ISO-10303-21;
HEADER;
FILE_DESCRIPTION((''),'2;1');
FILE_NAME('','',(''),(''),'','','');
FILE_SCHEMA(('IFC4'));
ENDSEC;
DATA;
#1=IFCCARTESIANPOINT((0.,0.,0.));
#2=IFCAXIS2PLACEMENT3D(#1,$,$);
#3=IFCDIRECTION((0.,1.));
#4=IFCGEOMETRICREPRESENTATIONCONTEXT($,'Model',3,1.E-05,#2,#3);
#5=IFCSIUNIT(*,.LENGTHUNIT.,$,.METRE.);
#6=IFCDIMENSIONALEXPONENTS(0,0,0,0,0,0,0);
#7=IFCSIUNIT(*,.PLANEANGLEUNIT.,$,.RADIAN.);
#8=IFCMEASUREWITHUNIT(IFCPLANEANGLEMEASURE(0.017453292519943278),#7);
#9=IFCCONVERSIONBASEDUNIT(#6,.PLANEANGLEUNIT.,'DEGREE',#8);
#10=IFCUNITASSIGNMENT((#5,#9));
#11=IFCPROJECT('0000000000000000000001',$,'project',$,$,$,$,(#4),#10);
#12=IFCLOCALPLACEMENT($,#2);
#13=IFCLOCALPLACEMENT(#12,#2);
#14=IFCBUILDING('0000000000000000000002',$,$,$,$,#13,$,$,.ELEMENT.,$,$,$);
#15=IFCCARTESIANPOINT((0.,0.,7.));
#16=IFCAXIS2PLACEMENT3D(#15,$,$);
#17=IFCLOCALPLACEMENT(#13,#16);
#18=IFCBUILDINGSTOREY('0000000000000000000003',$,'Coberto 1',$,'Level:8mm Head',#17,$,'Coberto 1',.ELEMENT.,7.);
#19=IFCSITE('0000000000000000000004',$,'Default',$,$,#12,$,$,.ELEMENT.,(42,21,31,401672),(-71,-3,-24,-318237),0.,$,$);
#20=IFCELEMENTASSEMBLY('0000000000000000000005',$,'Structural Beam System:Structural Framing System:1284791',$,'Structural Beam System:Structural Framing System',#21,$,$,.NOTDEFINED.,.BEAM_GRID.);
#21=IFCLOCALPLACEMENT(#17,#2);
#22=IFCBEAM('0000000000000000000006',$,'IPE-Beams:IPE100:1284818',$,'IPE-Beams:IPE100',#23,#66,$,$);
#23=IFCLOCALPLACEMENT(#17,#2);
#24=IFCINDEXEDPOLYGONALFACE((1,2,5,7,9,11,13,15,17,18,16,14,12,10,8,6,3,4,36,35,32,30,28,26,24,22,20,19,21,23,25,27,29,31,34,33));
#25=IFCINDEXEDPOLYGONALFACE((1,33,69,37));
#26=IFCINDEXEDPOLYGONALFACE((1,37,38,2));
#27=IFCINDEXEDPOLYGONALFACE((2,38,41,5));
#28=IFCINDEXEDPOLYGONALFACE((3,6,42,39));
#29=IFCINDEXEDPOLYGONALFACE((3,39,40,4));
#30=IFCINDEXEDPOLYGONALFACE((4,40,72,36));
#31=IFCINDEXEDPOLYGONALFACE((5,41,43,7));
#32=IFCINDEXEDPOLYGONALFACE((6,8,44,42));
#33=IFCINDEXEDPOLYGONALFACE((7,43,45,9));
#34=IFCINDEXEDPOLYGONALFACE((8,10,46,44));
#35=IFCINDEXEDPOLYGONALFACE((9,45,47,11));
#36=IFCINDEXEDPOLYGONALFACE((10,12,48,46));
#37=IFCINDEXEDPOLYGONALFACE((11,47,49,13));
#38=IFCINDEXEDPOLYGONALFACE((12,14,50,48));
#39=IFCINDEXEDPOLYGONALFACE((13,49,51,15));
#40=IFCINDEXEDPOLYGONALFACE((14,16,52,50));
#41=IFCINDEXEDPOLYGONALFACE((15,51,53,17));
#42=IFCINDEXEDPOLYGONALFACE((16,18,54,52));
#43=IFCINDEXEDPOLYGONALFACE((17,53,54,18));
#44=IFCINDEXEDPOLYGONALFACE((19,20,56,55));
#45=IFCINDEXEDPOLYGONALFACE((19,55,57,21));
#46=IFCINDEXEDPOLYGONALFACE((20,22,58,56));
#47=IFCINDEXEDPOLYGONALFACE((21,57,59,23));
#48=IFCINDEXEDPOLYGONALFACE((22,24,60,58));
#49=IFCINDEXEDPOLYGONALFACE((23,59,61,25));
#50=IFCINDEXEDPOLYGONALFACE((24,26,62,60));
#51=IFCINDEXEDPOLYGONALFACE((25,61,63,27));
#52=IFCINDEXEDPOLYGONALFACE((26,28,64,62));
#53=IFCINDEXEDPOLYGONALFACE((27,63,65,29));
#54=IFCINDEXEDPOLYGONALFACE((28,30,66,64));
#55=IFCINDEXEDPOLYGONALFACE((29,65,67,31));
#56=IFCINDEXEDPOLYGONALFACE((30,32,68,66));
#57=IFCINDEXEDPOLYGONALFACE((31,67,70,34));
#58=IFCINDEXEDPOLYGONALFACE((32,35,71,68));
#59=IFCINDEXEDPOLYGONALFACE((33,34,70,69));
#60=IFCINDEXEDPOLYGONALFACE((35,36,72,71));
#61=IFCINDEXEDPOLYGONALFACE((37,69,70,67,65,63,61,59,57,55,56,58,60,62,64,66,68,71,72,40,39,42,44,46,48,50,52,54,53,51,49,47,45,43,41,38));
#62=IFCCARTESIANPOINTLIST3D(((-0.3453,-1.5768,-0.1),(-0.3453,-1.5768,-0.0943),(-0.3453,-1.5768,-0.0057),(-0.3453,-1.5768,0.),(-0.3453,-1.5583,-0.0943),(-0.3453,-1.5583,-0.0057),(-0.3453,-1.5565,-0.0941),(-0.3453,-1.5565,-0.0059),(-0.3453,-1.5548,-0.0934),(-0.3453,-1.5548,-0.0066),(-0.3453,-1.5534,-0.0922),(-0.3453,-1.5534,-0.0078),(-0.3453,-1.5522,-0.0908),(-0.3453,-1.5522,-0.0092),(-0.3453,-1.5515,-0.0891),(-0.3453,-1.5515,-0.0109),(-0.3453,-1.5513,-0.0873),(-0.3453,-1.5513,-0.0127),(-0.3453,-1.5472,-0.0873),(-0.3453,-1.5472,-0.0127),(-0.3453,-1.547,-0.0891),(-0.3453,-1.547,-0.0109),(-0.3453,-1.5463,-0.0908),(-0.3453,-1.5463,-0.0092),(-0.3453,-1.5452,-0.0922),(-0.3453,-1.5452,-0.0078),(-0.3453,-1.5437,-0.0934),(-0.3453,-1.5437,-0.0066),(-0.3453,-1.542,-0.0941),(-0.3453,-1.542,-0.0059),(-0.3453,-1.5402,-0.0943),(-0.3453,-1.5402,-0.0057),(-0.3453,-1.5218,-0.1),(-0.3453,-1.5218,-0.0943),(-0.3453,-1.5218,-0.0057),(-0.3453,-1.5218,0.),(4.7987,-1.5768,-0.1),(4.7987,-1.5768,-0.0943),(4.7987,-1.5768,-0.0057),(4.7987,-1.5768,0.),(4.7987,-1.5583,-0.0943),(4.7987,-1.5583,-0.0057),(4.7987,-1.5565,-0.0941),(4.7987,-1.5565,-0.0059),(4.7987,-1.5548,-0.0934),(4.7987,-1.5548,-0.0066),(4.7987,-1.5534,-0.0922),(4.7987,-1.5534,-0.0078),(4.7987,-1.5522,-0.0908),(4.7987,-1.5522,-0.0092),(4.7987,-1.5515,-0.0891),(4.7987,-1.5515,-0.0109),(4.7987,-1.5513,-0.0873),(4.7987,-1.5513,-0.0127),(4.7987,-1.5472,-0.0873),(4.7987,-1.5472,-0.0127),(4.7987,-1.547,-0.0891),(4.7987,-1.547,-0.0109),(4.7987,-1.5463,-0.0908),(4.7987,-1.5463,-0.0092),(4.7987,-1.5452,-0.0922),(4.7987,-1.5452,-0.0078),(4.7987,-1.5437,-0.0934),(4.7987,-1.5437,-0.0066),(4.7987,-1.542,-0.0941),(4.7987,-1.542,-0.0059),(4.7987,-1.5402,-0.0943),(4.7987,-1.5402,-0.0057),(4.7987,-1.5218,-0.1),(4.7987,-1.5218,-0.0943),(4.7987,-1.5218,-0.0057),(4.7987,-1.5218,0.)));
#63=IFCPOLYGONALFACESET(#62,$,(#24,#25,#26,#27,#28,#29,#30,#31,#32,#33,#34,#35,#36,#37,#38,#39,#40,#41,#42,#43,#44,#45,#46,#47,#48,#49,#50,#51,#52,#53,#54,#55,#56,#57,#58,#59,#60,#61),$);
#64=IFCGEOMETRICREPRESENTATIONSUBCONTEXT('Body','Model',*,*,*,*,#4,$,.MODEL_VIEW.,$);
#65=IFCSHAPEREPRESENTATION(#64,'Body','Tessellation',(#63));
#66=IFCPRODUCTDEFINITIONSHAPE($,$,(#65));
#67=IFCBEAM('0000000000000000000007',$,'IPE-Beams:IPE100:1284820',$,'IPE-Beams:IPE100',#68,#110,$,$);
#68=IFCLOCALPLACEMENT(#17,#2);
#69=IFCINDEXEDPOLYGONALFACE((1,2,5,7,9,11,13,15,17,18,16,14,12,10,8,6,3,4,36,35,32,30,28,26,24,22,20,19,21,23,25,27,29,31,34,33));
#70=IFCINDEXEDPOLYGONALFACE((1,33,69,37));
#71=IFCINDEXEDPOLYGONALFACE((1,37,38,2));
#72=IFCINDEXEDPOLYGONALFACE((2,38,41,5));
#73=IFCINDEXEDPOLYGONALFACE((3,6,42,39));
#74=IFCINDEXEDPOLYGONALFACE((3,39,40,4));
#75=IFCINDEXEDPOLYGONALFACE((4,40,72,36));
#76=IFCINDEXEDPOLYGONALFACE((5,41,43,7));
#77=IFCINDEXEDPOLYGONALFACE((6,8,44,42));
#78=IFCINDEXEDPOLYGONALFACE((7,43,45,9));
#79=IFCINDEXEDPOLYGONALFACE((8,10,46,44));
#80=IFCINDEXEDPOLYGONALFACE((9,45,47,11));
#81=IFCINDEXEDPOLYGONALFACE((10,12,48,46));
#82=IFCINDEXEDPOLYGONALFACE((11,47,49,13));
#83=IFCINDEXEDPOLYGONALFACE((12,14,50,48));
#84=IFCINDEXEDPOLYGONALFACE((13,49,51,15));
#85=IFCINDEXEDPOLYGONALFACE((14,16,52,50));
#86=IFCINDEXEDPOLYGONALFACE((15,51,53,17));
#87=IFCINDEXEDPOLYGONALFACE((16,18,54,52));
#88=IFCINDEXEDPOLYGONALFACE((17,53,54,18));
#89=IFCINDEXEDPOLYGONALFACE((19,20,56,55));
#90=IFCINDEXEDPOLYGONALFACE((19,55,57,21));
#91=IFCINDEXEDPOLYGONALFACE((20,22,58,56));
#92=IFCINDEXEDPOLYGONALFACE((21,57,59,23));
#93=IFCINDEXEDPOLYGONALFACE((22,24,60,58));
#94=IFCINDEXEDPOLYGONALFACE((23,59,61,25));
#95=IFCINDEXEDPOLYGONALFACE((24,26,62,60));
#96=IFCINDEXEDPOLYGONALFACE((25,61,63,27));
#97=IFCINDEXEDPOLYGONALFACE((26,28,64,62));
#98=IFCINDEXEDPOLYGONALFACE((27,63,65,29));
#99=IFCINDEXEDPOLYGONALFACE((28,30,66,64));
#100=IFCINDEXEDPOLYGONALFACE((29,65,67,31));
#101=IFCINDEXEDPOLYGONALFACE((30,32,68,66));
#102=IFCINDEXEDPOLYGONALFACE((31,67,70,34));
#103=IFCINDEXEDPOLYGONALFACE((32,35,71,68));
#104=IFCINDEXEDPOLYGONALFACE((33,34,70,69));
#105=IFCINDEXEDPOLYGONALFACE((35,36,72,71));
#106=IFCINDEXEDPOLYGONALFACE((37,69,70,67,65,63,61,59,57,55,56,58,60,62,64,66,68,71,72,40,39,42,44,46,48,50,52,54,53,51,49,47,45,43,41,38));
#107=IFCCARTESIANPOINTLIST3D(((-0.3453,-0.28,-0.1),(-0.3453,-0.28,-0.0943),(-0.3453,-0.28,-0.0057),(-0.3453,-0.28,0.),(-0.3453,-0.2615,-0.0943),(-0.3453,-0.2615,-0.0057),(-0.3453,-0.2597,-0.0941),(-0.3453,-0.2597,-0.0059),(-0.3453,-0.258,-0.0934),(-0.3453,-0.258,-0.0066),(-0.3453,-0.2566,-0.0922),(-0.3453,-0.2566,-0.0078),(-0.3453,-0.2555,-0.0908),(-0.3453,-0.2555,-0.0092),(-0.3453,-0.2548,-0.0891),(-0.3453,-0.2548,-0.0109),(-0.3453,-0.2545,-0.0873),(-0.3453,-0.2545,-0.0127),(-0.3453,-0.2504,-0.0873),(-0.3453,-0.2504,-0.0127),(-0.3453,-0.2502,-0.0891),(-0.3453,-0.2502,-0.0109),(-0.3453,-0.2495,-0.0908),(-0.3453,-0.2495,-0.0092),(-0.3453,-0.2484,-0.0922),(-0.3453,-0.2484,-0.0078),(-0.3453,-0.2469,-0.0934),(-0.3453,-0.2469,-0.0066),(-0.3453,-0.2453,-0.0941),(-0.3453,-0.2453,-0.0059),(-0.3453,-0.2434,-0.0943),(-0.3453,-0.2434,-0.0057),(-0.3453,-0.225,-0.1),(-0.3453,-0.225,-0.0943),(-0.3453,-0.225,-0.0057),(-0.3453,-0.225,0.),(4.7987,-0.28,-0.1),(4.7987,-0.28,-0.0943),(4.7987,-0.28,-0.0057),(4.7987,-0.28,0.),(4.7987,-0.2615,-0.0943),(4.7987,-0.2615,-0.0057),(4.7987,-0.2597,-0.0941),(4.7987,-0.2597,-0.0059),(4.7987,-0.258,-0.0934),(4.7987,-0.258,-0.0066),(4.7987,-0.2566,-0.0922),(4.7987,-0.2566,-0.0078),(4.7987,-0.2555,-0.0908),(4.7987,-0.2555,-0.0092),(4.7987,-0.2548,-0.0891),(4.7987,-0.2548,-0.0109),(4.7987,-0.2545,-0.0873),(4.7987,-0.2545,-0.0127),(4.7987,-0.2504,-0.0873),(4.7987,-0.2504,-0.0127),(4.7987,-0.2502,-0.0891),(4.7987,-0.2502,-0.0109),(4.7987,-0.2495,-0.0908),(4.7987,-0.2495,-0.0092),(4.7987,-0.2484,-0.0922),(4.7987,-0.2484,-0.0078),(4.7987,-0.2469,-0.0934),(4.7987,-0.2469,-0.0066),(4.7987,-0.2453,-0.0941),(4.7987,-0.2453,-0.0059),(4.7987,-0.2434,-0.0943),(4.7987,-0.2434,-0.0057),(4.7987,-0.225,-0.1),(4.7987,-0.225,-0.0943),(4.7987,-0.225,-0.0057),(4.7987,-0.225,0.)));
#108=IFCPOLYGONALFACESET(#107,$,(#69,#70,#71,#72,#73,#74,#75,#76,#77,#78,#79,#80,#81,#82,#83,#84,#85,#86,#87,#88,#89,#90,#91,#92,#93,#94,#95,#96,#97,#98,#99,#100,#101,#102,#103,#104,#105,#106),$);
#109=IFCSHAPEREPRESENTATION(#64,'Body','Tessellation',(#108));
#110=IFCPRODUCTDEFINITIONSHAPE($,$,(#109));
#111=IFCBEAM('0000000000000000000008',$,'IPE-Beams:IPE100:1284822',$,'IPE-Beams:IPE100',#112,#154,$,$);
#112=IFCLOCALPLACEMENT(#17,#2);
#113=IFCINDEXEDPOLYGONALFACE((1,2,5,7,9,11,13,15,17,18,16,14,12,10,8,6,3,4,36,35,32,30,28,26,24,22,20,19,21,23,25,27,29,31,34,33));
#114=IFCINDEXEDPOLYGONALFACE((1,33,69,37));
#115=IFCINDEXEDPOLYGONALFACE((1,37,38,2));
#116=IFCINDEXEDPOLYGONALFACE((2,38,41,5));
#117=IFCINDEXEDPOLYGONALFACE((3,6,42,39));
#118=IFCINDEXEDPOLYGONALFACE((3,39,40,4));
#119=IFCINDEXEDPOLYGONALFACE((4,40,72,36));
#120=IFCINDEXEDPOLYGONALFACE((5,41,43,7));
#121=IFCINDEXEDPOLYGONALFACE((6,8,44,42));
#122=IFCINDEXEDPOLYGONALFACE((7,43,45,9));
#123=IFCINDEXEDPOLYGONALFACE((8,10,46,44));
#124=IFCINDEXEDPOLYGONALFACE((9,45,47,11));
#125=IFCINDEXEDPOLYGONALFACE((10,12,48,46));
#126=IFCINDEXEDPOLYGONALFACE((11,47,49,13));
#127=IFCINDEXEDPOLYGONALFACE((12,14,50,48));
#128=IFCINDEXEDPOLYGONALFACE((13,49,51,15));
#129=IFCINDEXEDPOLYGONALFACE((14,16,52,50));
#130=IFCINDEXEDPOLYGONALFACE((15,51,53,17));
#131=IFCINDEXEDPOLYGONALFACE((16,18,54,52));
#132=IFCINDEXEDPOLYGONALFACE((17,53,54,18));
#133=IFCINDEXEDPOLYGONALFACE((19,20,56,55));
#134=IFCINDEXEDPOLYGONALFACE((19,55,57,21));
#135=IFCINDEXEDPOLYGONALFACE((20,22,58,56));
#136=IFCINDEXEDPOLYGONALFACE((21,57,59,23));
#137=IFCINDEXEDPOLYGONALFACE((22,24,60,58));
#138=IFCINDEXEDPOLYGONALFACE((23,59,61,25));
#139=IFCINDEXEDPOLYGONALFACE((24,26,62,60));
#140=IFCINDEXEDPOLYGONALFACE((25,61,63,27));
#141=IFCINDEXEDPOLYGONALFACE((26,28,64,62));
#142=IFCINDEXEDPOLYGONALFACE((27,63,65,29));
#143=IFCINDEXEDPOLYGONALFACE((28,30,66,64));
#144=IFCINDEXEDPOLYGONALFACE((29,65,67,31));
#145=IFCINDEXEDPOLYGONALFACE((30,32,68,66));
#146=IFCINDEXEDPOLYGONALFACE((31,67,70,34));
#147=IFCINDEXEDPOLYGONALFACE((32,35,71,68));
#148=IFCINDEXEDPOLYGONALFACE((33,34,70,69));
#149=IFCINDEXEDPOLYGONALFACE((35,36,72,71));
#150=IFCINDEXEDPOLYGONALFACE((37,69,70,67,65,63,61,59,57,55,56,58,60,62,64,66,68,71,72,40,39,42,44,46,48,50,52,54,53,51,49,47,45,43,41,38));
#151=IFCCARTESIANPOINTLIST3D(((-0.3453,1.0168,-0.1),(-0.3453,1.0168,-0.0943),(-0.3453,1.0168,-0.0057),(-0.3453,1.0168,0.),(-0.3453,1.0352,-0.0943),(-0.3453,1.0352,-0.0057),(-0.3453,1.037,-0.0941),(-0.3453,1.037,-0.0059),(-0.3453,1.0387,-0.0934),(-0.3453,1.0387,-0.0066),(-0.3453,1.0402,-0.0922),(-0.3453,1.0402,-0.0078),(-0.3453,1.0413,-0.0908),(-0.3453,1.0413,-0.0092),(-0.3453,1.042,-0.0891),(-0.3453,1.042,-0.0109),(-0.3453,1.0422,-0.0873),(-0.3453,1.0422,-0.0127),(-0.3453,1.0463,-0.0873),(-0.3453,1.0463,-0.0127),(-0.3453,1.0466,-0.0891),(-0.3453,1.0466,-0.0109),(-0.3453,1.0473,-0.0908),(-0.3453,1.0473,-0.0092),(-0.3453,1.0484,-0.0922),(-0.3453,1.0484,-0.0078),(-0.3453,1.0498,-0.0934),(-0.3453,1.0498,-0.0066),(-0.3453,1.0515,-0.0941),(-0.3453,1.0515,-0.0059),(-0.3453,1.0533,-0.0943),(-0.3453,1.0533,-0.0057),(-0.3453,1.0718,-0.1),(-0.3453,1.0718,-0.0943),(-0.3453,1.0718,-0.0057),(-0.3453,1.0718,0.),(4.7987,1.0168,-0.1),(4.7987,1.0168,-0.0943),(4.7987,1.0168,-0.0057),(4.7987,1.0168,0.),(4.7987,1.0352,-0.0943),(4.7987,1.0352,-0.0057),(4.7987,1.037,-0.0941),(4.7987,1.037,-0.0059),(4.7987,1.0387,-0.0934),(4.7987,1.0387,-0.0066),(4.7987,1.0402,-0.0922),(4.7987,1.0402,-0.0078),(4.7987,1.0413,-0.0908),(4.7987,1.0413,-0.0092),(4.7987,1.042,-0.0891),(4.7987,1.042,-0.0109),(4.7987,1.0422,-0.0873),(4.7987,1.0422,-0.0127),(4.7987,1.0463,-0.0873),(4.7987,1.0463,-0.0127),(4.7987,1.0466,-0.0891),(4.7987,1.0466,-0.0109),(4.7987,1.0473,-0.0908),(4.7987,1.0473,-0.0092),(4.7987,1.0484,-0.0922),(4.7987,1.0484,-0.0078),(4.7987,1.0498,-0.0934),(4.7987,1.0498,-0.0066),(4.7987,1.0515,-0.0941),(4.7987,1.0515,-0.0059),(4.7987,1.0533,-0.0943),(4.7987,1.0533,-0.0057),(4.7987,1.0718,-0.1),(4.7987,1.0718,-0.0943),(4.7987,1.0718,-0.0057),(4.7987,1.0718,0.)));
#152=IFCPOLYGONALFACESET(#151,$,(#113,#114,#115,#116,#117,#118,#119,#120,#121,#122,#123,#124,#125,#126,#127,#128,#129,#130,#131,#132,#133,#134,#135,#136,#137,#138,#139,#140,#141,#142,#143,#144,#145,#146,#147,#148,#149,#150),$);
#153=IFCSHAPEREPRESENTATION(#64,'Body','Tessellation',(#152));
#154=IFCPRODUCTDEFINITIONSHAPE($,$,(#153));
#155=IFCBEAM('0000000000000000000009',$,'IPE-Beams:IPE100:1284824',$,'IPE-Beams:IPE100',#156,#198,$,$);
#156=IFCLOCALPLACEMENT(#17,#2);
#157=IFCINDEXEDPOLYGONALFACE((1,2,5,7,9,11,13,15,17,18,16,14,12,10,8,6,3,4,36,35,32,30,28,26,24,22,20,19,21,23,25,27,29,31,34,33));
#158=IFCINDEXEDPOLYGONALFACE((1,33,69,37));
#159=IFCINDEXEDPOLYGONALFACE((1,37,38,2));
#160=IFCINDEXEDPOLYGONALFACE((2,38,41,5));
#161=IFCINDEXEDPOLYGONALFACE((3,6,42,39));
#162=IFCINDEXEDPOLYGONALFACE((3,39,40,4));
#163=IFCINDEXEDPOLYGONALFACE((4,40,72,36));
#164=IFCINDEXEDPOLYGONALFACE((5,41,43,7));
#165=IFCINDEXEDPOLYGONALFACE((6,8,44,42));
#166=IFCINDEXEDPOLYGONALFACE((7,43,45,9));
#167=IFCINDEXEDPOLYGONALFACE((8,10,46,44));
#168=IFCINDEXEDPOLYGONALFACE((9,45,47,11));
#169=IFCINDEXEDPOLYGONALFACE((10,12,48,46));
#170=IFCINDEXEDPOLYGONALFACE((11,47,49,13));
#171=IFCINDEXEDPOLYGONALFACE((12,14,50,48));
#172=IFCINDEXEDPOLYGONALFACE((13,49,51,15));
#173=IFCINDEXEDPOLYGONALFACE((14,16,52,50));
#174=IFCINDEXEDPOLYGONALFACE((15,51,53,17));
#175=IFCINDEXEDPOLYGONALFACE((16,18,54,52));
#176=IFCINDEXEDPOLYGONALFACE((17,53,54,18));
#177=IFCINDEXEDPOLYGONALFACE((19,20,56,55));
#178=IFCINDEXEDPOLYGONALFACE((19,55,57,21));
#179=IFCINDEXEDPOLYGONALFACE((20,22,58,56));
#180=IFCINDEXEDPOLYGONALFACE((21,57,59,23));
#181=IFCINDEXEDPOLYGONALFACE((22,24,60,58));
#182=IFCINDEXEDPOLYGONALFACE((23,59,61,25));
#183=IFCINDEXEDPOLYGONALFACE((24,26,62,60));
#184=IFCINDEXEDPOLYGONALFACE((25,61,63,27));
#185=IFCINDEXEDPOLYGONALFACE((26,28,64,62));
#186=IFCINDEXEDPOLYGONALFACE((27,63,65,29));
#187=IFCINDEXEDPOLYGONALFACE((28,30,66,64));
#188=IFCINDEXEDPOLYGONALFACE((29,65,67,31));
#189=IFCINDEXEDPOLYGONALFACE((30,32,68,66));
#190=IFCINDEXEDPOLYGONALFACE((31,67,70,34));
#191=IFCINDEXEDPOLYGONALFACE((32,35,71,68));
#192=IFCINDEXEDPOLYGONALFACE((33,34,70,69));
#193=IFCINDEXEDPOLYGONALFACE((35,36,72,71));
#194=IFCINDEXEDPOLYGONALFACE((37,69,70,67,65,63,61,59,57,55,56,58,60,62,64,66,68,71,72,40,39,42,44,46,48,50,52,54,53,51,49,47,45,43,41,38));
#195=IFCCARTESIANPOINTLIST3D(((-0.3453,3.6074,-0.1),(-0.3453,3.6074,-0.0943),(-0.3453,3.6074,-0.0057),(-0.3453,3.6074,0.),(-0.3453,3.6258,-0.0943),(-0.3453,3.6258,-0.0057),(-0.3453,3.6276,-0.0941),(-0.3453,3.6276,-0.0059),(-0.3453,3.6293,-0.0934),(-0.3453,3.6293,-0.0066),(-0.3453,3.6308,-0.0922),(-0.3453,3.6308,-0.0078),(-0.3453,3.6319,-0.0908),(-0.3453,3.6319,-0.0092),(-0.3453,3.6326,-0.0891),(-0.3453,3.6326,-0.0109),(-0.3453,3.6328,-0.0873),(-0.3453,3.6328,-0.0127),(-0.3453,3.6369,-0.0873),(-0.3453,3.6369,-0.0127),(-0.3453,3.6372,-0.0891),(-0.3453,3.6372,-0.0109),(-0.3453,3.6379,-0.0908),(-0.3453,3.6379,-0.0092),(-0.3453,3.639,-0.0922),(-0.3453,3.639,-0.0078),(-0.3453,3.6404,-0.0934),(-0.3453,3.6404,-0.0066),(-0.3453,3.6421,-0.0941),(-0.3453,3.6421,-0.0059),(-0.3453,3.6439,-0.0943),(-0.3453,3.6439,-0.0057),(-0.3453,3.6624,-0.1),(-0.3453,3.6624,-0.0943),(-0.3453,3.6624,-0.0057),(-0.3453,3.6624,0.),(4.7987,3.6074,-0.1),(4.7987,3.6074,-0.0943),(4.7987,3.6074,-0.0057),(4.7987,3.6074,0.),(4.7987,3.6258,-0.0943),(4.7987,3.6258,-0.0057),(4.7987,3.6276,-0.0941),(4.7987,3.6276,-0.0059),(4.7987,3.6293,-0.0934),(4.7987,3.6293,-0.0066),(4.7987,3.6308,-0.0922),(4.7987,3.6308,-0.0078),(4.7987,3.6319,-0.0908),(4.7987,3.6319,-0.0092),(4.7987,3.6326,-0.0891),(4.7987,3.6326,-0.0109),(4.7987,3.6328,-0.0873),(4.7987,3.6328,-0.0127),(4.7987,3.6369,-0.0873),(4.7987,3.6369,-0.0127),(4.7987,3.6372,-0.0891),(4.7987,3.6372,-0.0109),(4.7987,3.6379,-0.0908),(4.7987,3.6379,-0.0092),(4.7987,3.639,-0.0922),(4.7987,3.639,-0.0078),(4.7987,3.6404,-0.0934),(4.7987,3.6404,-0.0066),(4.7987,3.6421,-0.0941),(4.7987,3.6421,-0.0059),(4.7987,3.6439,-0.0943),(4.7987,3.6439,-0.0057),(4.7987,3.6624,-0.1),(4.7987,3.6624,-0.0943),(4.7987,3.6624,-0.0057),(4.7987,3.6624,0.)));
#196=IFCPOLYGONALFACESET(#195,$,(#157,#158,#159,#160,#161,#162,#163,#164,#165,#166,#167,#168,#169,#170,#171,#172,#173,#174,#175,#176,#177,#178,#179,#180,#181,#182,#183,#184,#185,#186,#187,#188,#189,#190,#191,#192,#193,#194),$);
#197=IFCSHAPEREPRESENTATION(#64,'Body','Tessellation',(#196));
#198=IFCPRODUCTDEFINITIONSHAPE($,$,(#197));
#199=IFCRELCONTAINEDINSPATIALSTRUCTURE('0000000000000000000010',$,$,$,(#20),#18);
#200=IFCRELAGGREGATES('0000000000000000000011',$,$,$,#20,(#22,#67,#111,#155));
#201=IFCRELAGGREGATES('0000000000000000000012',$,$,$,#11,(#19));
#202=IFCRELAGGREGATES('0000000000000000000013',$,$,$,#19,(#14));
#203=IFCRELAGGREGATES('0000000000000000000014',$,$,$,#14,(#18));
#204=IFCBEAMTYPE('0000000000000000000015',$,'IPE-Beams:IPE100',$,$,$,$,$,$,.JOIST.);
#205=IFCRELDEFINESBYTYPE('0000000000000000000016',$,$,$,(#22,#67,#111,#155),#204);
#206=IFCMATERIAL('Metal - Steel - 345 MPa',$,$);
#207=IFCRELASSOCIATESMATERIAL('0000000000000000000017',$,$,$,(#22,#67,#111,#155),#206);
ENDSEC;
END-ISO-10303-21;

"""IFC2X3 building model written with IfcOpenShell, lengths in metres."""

from ifc_helpers import new_model, entity, si_unit, converted_unit, direction, frame, frame_2d, origin, place, context, subcontext, project, spatial, i_section, extrude, material, type_object, element, aggregate, save


model = new_model("IFC2X3")

# Units and contexts
model_context = context("Model", 3, precision=1e-05, world=origin(), true_north=direction((0.0, 1.0)))
body_context = subcontext(model_context, "Body", "Model", "MODEL_VIEW")
ifc_project = project(units=[si_unit("LENGTHUNIT", "METRE"), converted_unit("PLANEANGLEUNIT", "DEGREE", entity("IfcPlaneAngleMeasure", 0.017453292519943278), si_unit("PLANEANGLEUNIT", "RADIAN"), dimensions=[0, 0, 0, 0, 0, 0, 0])], contexts=[model_context])

# Site, building, storey
site_placement = place(None, origin())
site = spatial("IfcSite", under=ifc_project, at=site_placement, Name="Default", CompositionType="ELEMENT", RefLatitude=(42, 21, 31, 401672), RefLongitude=(-71, -3, -24, -318237), RefElevation=0.0)
building_placement = place(site_placement, origin())
building = spatial("IfcBuilding", under=site, at=building_placement, CompositionType="ELEMENT")
storey_placement = place(building_placement, frame((0.0, 0.0, 7.0)))
storey = spatial("IfcBuildingStorey", under=building, at=storey_placement, Name="Coberto 1", ObjectType="Level:8mm Head", LongName="Coberto 1", CompositionType="ELEMENT", Elevation=7.0)

# Element assembly, beams
assembly_1_placement = place(storey_placement, origin())
assembly_1 = element("IfcElementAssembly", 1, at=assembly_1_placement, inside=storey, Name="Structural Beam System:Structural Framing System:1284791", ObjectType="Structural Beam System:Structural Framing System", AssemblyPlace="NOTDEFINED", PredefinedType="BEAM_GRID")
ifc_material_1 = material(Name="Metal - Steel - 345 MPa")
beam_type_1 = type_object("IfcBeamType", Name="IPE-Beams:IPE100", PredefinedType="JOIST")
beam_1_placement = place(assembly_1_placement, frame((4.8467, -1.5493, 0.0), z_axis=(0.0, 0.0, 1.0), x_axis=(-1.0, 0.0, 0.0)))
beam_1 = element("IfcBeam", 2, at=beam_1_placement, type_object=beam_type_1, material=ifc_material_1, Name="IPE-Beams:IPE100:1284818", ObjectType="IPE-Beams:IPE100", context=body_context, shape_type="SweptSolid", body=[
    extrude(i_section(OverallWidth=0.055, OverallDepth=0.1, WebThickness=0.0041, FlangeThickness=0.0057, FilletRadius=0.007, at=frame_2d((0.0, 0.0), x_axis=(0.0, 1.0))), frame((0.048, 0.0, -0.05), z_axis=(1.0, 0.0, 0.0), x_axis=(0.0, 0.0, -1.0)), (0.0, 0.0, 1.0), 5.144),
])
beam_2_placement = place(assembly_1_placement, frame((4.8467, -0.2525, 0.0), z_axis=(0.0, 0.0, 1.0), x_axis=(-1.0, 0.0, 0.0)))
beam_2 = element("IfcBeam", 3, at=beam_2_placement, type_object=beam_type_1, material=ifc_material_1, Name="IPE-Beams:IPE100:1284820", ObjectType="IPE-Beams:IPE100", context=body_context, shape_type="SweptSolid", body=[
    extrude(i_section(OverallWidth=0.055, OverallDepth=0.1, WebThickness=0.0041, FlangeThickness=0.0057, FilletRadius=0.007, at=frame_2d((0.0, 0.0), x_axis=(0.0, 1.0))), frame((0.048, 0.0, -0.05), z_axis=(1.0, 0.0, 0.0), x_axis=(0.0, 0.0, -1.0)), (0.0, 0.0, 1.0), 5.144),
])
beam_3_placement = place(assembly_1_placement, frame((4.8467, 1.0443, 0.0), z_axis=(0.0, 0.0, 1.0), x_axis=(-1.0, 0.0, 0.0)))
beam_3 = element("IfcBeam", 4, at=beam_3_placement, type_object=beam_type_1, material=ifc_material_1, Name="IPE-Beams:IPE100:1284822", ObjectType="IPE-Beams:IPE100", context=body_context, shape_type="SweptSolid", body=[
    extrude(i_section(OverallWidth=0.055, OverallDepth=0.1, WebThickness=0.0041, FlangeThickness=0.0057, FilletRadius=0.007, at=frame_2d((0.0, 0.0), x_axis=(0.0, 1.0))), frame((0.048, 0.0, -0.05), z_axis=(1.0, 0.0, 0.0), x_axis=(0.0, 0.0, -1.0)), (0.0, 0.0, 1.0), 5.144),
])
beam_4_placement = place(assembly_1_placement, frame((4.8467, 3.6349, 0.0), z_axis=(0.0, 0.0, 1.0), x_axis=(-1.0, 0.0, 0.0)))
beam_4 = element("IfcBeam", 5, at=beam_4_placement, type_object=beam_type_1, material=ifc_material_1, Name="IPE-Beams:IPE100:1284824", ObjectType="IPE-Beams:IPE100", context=body_context, shape_type="SweptSolid", body=[
    extrude(i_section(OverallWidth=0.055, OverallDepth=0.1, WebThickness=0.0041, FlangeThickness=0.0057, FilletRadius=0.007, at=frame_2d((0.0, 0.0), x_axis=(0.0, 1.0))), frame((0.048, 0.0, -0.05), z_axis=(1.0, 0.0, 0.0), x_axis=(0.0, 0.0, -1.0)), (0.0, 0.0, 1.0), 5.144),
])
aggregate(assembly_1, [beam_1, beam_2, beam_3, beam_4])

save(model, "model.ifc")
